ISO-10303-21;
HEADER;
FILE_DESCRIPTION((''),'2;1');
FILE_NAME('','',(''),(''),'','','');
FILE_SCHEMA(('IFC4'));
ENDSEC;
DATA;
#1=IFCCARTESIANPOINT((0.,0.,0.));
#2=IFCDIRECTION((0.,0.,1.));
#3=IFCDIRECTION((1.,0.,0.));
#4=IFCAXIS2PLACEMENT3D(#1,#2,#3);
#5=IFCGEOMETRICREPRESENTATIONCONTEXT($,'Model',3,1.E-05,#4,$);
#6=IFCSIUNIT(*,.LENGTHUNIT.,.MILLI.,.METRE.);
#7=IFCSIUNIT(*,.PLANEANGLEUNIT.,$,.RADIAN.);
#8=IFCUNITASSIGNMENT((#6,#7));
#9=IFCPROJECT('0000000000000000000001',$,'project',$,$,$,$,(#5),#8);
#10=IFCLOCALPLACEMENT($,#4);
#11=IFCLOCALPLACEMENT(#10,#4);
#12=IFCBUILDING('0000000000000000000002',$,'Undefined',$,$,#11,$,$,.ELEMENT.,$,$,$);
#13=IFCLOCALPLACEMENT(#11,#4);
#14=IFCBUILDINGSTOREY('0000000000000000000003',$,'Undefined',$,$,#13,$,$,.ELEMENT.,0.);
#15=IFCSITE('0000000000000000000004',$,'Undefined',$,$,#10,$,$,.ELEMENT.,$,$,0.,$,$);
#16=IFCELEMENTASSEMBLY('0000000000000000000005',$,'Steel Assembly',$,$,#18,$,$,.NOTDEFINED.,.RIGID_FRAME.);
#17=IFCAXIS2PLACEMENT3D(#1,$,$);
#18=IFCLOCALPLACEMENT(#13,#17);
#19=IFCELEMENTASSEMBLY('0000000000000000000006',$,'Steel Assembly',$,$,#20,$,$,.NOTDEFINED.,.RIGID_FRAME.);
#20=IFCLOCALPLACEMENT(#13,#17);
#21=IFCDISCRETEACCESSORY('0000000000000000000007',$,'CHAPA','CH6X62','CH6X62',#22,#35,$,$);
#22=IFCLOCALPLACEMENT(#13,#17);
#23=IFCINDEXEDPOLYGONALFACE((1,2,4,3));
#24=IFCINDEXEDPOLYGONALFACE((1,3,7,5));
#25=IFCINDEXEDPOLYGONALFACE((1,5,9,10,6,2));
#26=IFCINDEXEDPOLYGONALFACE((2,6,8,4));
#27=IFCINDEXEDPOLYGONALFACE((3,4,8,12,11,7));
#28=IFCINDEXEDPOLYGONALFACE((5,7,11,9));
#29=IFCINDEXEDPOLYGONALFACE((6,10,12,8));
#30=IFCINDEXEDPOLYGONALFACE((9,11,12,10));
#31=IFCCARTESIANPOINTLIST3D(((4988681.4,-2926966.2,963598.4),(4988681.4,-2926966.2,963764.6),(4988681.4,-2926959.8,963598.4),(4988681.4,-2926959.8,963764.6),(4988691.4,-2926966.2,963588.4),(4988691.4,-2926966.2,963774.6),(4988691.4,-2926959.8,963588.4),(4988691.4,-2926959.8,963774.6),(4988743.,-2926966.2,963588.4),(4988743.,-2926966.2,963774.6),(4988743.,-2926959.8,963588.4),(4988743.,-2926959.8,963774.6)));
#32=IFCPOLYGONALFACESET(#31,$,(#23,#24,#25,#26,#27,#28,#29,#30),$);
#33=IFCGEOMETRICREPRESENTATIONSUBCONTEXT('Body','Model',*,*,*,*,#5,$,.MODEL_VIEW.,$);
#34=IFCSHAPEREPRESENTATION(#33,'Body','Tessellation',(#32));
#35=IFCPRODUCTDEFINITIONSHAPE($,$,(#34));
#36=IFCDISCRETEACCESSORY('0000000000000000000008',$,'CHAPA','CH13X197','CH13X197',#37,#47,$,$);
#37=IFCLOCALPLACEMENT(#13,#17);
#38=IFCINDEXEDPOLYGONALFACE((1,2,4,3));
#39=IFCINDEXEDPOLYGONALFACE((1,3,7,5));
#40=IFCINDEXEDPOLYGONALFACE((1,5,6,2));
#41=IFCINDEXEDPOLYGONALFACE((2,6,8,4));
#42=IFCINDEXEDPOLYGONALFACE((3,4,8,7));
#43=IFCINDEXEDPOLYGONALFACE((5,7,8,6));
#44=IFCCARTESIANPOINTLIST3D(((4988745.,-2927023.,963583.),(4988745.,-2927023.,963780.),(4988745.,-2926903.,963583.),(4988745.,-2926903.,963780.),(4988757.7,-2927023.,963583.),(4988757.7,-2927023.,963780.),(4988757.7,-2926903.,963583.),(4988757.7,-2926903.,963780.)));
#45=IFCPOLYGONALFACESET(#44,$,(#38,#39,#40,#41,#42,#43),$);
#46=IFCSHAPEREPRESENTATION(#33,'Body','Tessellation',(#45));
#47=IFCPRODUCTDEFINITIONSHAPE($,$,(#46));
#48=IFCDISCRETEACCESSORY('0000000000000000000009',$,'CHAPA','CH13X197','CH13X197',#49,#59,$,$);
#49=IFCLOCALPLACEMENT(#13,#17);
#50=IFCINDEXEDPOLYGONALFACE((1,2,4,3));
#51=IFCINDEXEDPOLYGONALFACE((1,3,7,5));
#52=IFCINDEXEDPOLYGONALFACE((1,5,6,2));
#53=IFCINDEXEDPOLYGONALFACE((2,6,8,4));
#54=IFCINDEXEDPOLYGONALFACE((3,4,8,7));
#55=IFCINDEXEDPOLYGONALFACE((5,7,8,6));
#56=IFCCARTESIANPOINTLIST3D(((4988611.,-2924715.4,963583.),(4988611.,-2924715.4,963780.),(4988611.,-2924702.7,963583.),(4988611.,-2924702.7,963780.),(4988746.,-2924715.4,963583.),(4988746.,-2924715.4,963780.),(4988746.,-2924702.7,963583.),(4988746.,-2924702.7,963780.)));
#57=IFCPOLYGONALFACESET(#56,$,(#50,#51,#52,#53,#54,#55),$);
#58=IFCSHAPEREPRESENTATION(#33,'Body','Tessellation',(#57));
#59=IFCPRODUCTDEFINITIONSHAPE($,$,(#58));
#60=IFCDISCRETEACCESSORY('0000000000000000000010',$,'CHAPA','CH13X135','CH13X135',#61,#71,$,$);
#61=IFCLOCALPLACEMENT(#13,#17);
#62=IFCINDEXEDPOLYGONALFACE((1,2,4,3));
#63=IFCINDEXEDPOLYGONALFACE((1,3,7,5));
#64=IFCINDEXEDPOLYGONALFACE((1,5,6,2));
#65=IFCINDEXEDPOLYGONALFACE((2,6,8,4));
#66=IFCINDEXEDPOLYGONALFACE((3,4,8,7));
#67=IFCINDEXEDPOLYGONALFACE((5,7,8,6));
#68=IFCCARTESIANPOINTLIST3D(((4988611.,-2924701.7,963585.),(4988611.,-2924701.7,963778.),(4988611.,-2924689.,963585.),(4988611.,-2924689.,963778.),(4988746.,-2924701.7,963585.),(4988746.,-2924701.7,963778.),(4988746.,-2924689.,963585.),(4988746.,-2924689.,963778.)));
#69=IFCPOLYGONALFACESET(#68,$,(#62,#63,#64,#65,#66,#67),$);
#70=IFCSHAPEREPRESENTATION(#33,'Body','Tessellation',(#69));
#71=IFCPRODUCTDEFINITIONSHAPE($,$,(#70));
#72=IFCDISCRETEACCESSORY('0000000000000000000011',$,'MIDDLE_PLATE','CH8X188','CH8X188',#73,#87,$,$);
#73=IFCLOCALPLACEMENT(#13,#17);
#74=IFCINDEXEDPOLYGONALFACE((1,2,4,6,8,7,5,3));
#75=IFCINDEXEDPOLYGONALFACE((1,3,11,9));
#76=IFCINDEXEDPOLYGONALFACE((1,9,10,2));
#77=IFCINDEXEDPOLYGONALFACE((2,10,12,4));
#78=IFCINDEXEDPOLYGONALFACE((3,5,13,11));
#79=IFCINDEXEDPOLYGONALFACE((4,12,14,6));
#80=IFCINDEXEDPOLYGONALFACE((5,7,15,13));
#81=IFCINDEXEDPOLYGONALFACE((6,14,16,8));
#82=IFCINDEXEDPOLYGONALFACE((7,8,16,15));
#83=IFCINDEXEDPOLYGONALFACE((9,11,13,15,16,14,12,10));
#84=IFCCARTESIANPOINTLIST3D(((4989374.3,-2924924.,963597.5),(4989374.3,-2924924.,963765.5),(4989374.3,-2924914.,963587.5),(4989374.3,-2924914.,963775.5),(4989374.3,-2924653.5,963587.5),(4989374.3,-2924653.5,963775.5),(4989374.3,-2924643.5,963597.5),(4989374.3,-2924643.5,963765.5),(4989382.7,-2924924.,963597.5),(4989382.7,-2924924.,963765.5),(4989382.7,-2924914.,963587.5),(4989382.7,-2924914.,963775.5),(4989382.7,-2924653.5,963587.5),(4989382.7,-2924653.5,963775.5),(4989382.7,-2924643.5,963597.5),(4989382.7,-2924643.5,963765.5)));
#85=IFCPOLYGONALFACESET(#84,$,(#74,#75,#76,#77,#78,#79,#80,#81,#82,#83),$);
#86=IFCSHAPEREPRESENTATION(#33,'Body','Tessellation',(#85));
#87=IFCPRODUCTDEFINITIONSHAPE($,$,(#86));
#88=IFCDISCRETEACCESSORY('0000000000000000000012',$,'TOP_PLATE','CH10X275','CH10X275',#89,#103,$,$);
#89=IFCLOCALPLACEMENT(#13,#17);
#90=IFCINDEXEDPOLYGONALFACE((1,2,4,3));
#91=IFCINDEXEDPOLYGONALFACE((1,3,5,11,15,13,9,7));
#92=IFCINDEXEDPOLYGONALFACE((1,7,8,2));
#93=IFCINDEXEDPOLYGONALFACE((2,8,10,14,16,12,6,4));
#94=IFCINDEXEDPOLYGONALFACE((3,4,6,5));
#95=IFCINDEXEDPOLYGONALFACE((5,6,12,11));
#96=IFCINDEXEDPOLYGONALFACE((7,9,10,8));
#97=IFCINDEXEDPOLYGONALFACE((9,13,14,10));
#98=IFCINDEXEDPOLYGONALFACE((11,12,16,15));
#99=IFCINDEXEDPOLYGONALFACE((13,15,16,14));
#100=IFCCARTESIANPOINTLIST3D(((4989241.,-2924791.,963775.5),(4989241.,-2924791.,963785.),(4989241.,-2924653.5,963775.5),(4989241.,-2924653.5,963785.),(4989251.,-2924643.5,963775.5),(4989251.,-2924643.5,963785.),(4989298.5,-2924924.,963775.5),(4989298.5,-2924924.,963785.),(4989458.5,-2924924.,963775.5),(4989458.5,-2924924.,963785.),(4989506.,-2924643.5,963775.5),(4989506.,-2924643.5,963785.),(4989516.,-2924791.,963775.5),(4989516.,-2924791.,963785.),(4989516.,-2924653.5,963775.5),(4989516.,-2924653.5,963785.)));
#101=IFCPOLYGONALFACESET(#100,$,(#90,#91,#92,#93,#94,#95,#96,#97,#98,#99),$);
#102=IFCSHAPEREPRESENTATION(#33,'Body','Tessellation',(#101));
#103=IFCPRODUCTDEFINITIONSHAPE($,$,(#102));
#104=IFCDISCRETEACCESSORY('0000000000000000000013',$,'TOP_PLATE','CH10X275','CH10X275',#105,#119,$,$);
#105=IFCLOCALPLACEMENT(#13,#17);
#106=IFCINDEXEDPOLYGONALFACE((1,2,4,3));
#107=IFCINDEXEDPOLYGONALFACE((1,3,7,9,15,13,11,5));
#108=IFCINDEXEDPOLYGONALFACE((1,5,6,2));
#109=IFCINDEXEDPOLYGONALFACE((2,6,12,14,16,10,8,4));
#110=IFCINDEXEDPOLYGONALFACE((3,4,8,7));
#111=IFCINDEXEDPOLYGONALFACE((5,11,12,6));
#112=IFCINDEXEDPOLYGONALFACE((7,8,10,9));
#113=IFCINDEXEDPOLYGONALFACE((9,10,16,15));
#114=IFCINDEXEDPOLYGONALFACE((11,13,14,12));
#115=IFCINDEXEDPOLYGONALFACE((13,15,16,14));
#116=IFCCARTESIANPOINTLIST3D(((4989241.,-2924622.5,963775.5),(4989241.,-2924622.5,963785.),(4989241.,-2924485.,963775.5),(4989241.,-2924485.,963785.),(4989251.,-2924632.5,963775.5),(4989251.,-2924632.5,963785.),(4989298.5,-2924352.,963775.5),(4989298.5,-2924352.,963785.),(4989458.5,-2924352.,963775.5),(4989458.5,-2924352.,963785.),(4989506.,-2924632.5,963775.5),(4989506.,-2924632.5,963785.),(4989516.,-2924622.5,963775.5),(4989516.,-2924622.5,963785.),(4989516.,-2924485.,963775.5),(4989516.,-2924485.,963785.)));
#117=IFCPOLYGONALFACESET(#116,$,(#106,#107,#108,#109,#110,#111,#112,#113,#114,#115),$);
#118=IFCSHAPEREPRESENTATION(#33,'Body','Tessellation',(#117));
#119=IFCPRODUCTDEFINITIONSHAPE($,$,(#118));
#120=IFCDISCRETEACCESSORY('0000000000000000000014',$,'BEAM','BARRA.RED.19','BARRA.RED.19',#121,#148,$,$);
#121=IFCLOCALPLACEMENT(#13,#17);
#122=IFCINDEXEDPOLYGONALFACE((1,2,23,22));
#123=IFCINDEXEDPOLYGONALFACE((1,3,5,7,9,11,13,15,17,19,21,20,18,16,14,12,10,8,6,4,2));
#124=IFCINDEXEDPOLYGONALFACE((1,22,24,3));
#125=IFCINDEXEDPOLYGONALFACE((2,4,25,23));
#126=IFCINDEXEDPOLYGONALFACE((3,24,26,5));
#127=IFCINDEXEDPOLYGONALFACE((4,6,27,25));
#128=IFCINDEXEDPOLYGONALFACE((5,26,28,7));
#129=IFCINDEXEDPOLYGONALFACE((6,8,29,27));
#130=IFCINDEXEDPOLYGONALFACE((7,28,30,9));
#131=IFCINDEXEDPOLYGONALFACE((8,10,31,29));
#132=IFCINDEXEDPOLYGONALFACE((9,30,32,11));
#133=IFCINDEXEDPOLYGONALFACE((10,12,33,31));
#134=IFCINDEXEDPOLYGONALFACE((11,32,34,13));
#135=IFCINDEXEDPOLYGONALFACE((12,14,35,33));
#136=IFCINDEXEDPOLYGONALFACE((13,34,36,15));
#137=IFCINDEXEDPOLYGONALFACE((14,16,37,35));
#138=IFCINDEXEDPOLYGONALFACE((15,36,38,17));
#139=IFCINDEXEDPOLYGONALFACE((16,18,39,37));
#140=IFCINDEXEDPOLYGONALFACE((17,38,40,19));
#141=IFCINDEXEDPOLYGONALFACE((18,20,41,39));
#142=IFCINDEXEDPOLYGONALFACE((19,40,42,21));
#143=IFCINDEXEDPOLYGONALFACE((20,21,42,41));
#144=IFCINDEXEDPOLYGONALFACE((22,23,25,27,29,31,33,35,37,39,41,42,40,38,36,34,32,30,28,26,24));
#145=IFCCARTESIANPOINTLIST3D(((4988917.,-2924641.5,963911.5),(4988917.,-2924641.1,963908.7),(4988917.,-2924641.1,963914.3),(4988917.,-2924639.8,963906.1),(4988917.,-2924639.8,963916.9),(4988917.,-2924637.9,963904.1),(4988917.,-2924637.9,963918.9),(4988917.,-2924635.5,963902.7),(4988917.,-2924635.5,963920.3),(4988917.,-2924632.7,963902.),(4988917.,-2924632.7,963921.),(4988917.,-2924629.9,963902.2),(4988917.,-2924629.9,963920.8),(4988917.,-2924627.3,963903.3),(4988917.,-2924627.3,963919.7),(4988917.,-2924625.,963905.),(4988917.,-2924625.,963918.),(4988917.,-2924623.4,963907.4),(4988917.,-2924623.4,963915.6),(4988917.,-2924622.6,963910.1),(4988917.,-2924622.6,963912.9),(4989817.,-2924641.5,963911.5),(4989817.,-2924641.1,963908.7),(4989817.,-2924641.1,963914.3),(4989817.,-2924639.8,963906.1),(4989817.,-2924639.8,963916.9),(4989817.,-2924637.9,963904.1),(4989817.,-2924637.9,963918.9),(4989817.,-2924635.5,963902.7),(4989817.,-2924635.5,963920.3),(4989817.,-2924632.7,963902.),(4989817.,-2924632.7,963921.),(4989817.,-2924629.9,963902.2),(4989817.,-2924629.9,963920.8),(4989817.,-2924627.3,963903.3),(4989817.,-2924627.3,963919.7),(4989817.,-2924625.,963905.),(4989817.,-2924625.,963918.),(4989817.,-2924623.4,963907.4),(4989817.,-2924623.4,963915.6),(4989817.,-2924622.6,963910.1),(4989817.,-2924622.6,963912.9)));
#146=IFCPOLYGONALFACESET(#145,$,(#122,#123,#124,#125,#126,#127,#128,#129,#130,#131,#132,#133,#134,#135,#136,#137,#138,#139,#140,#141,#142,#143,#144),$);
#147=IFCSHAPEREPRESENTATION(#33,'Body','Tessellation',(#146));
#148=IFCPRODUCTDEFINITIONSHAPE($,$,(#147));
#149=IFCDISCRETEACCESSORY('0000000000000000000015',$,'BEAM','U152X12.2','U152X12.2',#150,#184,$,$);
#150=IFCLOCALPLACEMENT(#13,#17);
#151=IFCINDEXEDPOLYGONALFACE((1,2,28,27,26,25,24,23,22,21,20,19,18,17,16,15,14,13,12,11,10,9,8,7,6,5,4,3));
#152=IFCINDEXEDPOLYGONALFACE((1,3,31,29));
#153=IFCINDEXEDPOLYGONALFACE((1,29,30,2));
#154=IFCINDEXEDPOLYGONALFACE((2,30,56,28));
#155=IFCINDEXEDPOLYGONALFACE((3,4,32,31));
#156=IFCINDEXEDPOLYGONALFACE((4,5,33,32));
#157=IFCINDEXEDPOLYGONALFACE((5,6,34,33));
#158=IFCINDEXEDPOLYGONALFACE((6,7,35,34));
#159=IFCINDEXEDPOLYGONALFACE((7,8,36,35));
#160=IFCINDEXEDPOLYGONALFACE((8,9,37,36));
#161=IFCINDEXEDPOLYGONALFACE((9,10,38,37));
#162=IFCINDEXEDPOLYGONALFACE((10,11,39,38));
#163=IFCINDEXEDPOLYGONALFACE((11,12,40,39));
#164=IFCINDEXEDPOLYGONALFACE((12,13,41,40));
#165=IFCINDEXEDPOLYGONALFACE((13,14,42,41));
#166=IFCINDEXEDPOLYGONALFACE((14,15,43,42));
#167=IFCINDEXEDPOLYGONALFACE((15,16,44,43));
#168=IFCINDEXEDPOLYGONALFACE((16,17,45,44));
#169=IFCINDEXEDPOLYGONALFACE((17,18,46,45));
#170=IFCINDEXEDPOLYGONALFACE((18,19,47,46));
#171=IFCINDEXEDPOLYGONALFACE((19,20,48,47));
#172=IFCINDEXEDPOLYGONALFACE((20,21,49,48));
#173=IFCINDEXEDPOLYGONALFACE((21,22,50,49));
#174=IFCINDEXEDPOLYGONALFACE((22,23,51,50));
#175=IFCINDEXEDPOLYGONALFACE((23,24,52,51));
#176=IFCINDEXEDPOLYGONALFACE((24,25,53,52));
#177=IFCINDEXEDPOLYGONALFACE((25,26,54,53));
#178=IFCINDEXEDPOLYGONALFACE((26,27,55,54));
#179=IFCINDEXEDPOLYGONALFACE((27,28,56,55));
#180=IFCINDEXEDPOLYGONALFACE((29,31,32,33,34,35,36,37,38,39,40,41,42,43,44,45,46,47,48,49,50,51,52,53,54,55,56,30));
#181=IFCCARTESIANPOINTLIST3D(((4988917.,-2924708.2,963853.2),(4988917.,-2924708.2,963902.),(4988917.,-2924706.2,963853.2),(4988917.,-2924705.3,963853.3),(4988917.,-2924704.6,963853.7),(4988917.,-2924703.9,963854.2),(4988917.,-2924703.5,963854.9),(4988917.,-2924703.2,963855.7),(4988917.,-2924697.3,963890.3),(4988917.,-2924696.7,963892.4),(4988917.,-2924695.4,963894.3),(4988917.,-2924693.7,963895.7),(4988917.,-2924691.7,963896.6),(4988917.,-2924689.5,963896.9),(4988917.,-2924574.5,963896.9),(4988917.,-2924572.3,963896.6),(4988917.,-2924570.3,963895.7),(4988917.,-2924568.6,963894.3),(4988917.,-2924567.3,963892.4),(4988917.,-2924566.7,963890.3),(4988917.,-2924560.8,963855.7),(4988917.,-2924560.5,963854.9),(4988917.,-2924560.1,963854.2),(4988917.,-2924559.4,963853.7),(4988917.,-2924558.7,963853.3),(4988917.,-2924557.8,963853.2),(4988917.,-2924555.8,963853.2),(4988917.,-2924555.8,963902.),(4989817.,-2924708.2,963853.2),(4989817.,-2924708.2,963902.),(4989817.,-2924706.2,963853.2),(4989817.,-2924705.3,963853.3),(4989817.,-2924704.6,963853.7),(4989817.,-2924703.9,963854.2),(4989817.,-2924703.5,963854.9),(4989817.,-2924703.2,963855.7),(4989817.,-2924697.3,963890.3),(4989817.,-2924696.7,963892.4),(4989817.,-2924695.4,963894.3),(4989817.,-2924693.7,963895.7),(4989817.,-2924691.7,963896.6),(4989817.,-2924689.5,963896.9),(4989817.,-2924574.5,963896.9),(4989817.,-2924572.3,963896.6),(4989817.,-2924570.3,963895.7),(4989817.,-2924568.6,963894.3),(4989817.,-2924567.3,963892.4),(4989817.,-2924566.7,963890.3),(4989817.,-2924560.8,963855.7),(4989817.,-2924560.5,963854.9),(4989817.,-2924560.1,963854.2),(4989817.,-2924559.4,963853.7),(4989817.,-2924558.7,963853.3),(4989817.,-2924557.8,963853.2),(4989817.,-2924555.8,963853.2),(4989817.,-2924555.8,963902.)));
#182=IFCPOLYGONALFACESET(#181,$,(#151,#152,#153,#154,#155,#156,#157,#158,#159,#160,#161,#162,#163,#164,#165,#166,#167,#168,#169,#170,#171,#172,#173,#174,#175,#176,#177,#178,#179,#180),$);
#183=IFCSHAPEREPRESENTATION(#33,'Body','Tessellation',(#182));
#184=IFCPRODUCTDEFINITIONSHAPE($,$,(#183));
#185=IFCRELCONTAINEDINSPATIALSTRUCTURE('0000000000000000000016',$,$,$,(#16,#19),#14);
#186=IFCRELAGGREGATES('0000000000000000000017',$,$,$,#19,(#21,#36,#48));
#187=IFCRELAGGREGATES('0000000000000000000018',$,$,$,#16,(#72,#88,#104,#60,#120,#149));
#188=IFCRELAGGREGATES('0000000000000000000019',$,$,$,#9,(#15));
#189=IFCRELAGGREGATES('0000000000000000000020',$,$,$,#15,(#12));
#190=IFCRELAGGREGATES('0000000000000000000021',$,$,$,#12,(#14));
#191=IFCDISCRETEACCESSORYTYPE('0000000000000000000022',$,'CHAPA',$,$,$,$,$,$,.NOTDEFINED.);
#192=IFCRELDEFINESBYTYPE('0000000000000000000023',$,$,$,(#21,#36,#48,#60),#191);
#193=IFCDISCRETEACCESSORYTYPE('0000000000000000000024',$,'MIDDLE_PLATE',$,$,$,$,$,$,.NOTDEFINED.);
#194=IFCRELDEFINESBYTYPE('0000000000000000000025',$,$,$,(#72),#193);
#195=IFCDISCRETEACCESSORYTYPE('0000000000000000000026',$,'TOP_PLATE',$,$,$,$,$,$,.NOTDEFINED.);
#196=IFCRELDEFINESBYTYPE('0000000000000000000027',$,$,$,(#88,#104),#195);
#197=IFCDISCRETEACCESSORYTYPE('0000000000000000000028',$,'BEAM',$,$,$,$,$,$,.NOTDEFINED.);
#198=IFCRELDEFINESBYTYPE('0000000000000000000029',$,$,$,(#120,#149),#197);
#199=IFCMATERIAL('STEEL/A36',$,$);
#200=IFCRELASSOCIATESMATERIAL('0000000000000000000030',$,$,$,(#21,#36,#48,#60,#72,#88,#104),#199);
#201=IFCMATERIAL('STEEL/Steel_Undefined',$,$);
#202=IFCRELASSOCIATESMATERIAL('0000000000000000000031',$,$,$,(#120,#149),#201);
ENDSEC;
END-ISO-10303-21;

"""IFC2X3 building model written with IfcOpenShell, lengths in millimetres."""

from ifc_helpers import new_model, si_unit, frame, origin_with_axes, origin_2d_with_axis, place, context, subcontext, project, spatial, polyline, circle, u_section, outline, extrude, material, type_object, element, aggregate, save


model = new_model("IFC2X3")

# Units and contexts
model_context = context("Model", 3, precision=1e-05, world=origin_with_axes())
body_context = subcontext(model_context, "Body", "Model", "MODEL_VIEW")
ifc_project = project(units=[si_unit("LENGTHUNIT", "METRE", prefix="MILLI"), si_unit("PLANEANGLEUNIT", "RADIAN")], contexts=[model_context])

# Site, building, storey
site_placement = place(None, origin_with_axes())
site = spatial("IfcSite", under=ifc_project, at=site_placement, Name="Undefined", CompositionType="ELEMENT", RefElevation=0.0)
building_placement = place(site_placement, origin_with_axes())
building = spatial("IfcBuilding", under=site, at=building_placement, Name="Undefined", CompositionType="ELEMENT")
storey_placement = place(building_placement, origin_with_axes())
storey = spatial("IfcBuildingStorey", under=building, at=storey_placement, Name="Undefined", CompositionType="ELEMENT", Elevation=0.0)

# Shared definitions
ifc_material_1 = material(Name="STEEL/A36")
discrete_accessory_type_1 = type_object("IfcDiscreteAccessoryType", Name="CHAPA")

# Element assembly
assembly_1_placement = place(storey_placement, origin_with_axes())
assembly_1 = element("IfcElementAssembly", 1, at=assembly_1_placement, inside=storey, Name="Steel Assembly", AssemblyPlace="NOTDEFINED", PredefinedType="RIGID_FRAME")

# Element assembly, discrete accessories
assembly_2_placement = place(storey_placement, origin_with_axes())
assembly_2 = element("IfcElementAssembly", 2, at=assembly_2_placement, inside=storey, Name="Steel Assembly", AssemblyPlace="NOTDEFINED", PredefinedType="RIGID_FRAME")
discrete_accessory_1_placement = place(assembly_2_placement, frame((4988681.4, -2926963.0, 963774.6), z_axis=(0.0, 1.0, 0.0), x_axis=(1.0, 0.0, 0.0)))
discrete_accessory_1 = element("IfcDiscreteAccessory", 3, at=discrete_accessory_1_placement, type_object=discrete_accessory_type_1, material=ifc_material_1, Name="CHAPA", Description="CH6X62", ObjectType="CH6X62", context=body_context, shape_type="SweptSolid", body=[
    extrude(outline(polyline([(0.0, 10.0), (10.0, 0.0), (61.6, 0.0), (61.6, 186.2), (10.0, 186.2), (0.0, 176.2), (0.0, 10.0)])), frame((0.0, 0.0, -3.2), z_axis=(0.0, 0.0, 1.0), x_axis=(1.0, 0.0, 0.0)), (0.0, 0.0, 1.0), 6.4),
])
discrete_accessory_2_placement = place(assembly_2_placement, frame((4988751.3, -2926963.0, 963780.0), z_axis=(1.0, 0.0, 0.0), x_axis=(0.0, 0.0, -1.0)))
discrete_accessory_2 = element("IfcDiscreteAccessory", 4, at=discrete_accessory_2_placement, type_object=discrete_accessory_type_1, material=ifc_material_1, Name="CHAPA", Description="CH13X197", ObjectType="CH13X197", context=body_context, shape_type="SweptSolid", body=[
    extrude(outline(polyline([(197.0, -60.0), (0.0, -60.0), (0.0, 60.0), (197.0, 60.0), (197.0, -60.0)])), frame((0.0, 0.0, -6.3), z_axis=(0.0, 0.0, 1.0), x_axis=(1.0, 0.0, 0.0)), (0.0, 0.0, 1.0), 12.7),
])
discrete_accessory_3_placement = place(assembly_2_placement, frame((4988678.5, -2924709.1, 963780.0), z_axis=(0.0, -1.0, 0.0), x_axis=(0.0, 0.0, -1.0)))
discrete_accessory_3 = element("IfcDiscreteAccessory", 5, at=discrete_accessory_3_placement, type_object=discrete_accessory_type_1, material=ifc_material_1, Name="CHAPA", Description="CH13X197", ObjectType="CH13X197", context=body_context, shape_type="SweptSolid", body=[
    extrude(outline(polyline([(197.0, -67.5), (0.0, -67.5), (0.0, 67.5), (197.0, 67.5), (197.0, -67.5)])), frame((0.0, 0.0, -6.3), z_axis=(0.0, 0.0, 1.0), x_axis=(1.0, 0.0, 0.0)), (0.0, 0.0, 1.0), 12.7),
])
aggregate(assembly_2, [discrete_accessory_1, discrete_accessory_2, discrete_accessory_3])

# Discrete accessories
discrete_accessory_4_placement = place(assembly_1_placement, frame((4988678.5, -2924695.4, 963778.0), z_axis=(0.0, -1.0, 0.0), x_axis=(0.0, 0.0, -1.0)))
discrete_accessory_4 = element("IfcDiscreteAccessory", 6, at=discrete_accessory_4_placement, type_object=discrete_accessory_type_1, material=ifc_material_1, Name="CHAPA", Description="CH13X135", ObjectType="CH13X135", context=body_context, shape_type="SweptSolid", body=[
    extrude(outline(polyline([(193.0, -67.5), (0.0, -67.5), (0.0, 67.5), (193.0, 67.5), (193.0, -67.5)])), frame((0.0, 0.0, -6.3), z_axis=(0.0, 0.0, 1.0), x_axis=(1.0, 0.0, 0.0)), (0.0, 0.0, 1.0), 12.7),
])
discrete_accessory_type_2 = type_object("IfcDiscreteAccessoryType", Name="MIDDLE_PLATE")
discrete_accessory_5_placement = place(assembly_1_placement, frame((4989378.5, -2924924.0, 963775.5), z_axis=(-1.0, 0.0, 0.0), x_axis=(0.0, 1.0, 0.0)))
discrete_accessory_5 = element("IfcDiscreteAccessory", 7, at=discrete_accessory_5_placement, type_object=discrete_accessory_type_2, material=ifc_material_1, Name="MIDDLE_PLATE", Description="CH8X188", ObjectType="CH8X188", context=body_context, shape_type="SweptSolid", body=[
    extrude(outline(polyline([(0.0, 10.0), (10.0, 0.0), (270.5, 0.0), (280.5, 10.0), (280.5, 178.0), (270.5, 188.0), (10.0, 188.0), (0.0, 178.0), (0.0, 10.0)])), frame((0.0, 0.0, -4.2), z_axis=(0.0, 0.0, 1.0), x_axis=(1.0, 0.0, 0.0)), (0.0, 0.0, 1.0), 8.4),
])
discrete_accessory_type_3 = type_object("IfcDiscreteAccessoryType", Name="TOP_PLATE")
discrete_accessory_6_placement = place(assembly_1_placement, frame((4989516.0, -2924791.0, 963780.3), z_axis=(0.0, 0.0, 1.0), x_axis=(0.0, 1.0, 0.0)))
discrete_accessory_6 = element("IfcDiscreteAccessory", 8, at=discrete_accessory_6_placement, type_object=discrete_accessory_type_3, material=ifc_material_1, Name="TOP_PLATE", Description="CH10X275", ObjectType="CH10X275", context=body_context, shape_type="SweptSolid", body=[
    extrude(outline(polyline([(0.0, 0.0), (137.5, 0.0), (147.5, 10.0), (147.5, 265.0), (137.5, 275.0), (0.0, 275.0), (-133.0, 217.5), (-133.0, 57.5), (0.0, 0.0)])), frame((0.0, 0.0, -4.8), z_axis=(0.0, 0.0, 1.0), x_axis=(1.0, 0.0, 0.0)), (0.0, 0.0, 1.0), 9.5),
])
discrete_accessory_7_placement = place(assembly_1_placement, frame((4989241.0, -2924485.0, 963780.3), z_axis=(0.0, 0.0, 1.0), x_axis=(0.0, -1.0, 0.0)))
discrete_accessory_7 = element("IfcDiscreteAccessory", 9, at=discrete_accessory_7_placement, type_object=discrete_accessory_type_3, material=ifc_material_1, Name="TOP_PLATE", Description="CH10X275", ObjectType="CH10X275", context=body_context, shape_type="SweptSolid", body=[
    extrude(outline(polyline([(0.0, 0.0), (137.5, 0.0), (147.5, 10.0), (147.5, 265.0), (137.5, 275.0), (0.0, 275.0), (-133.0, 217.5), (-133.0, 57.5), (0.0, 0.0)])), frame((0.0, 0.0, -4.8), z_axis=(0.0, 0.0, 1.0), x_axis=(1.0, 0.0, 0.0)), (0.0, 0.0, 1.0), 9.5),
])
ifc_material_2 = material(Name="STEEL/Steel_Undefined")
discrete_accessory_type_4 = type_object("IfcDiscreteAccessoryType", Name="BEAM")
discrete_accessory_8_placement = place(assembly_1_placement, frame((4989817.0, -2924632.0, 963911.5), z_axis=(0.0, 0.0, -1.0), x_axis=(-1.0, 0.0, 0.0)))
discrete_accessory_8 = element("IfcDiscreteAccessory", 10, at=discrete_accessory_8_placement, type_object=discrete_accessory_type_4, material=ifc_material_2, Name="BEAM", Description="BARRA.RED.19", ObjectType="BARRA.RED.19", context=body_context, shape_type="SweptSolid", body=[
    extrude(circle(Radius=9.5, at=origin_2d_with_axis()), frame((900.0, 0.0, 0.0), z_axis=(-1.0, 0.0, 0.0), x_axis=(0.0, -1.0, 0.0)), (0.0, 0.0, 1.0), 900.0),
])
discrete_accessory_9_placement = place(assembly_1_placement, frame((4989817.0, -2924632.0, 963877.6), z_axis=(0.0, 1.0, 0.0), x_axis=(-1.0, 0.0, 0.0)))
discrete_accessory_9 = element("IfcDiscreteAccessory", 11, at=discrete_accessory_9_placement, type_object=discrete_accessory_type_4, material=ifc_material_2, Name="BEAM", Description="U152X12.2", ObjectType="U152X12.2", context=body_context, shape_type="SweptSolid", body=[
    extrude(u_section(Depth=152.4, FlangeWidth=48.8, WebThickness=5.1, FlangeThickness=8.7, FilletRadius=8.0, EdgeRadius=3.0, FlangeSlope=0.16839, at=origin_2d_with_axis()), frame((900.0, 0.0, 0.0), z_axis=(-1.0, 0.0, 0.0), x_axis=(0.0, -1.0, 0.0)), (0.0, 0.0, 1.0), 900.0),
])
aggregate(assembly_1, [discrete_accessory_5, discrete_accessory_6, discrete_accessory_7, discrete_accessory_4, discrete_accessory_8, discrete_accessory_9])

save(model, "model.ifc")
